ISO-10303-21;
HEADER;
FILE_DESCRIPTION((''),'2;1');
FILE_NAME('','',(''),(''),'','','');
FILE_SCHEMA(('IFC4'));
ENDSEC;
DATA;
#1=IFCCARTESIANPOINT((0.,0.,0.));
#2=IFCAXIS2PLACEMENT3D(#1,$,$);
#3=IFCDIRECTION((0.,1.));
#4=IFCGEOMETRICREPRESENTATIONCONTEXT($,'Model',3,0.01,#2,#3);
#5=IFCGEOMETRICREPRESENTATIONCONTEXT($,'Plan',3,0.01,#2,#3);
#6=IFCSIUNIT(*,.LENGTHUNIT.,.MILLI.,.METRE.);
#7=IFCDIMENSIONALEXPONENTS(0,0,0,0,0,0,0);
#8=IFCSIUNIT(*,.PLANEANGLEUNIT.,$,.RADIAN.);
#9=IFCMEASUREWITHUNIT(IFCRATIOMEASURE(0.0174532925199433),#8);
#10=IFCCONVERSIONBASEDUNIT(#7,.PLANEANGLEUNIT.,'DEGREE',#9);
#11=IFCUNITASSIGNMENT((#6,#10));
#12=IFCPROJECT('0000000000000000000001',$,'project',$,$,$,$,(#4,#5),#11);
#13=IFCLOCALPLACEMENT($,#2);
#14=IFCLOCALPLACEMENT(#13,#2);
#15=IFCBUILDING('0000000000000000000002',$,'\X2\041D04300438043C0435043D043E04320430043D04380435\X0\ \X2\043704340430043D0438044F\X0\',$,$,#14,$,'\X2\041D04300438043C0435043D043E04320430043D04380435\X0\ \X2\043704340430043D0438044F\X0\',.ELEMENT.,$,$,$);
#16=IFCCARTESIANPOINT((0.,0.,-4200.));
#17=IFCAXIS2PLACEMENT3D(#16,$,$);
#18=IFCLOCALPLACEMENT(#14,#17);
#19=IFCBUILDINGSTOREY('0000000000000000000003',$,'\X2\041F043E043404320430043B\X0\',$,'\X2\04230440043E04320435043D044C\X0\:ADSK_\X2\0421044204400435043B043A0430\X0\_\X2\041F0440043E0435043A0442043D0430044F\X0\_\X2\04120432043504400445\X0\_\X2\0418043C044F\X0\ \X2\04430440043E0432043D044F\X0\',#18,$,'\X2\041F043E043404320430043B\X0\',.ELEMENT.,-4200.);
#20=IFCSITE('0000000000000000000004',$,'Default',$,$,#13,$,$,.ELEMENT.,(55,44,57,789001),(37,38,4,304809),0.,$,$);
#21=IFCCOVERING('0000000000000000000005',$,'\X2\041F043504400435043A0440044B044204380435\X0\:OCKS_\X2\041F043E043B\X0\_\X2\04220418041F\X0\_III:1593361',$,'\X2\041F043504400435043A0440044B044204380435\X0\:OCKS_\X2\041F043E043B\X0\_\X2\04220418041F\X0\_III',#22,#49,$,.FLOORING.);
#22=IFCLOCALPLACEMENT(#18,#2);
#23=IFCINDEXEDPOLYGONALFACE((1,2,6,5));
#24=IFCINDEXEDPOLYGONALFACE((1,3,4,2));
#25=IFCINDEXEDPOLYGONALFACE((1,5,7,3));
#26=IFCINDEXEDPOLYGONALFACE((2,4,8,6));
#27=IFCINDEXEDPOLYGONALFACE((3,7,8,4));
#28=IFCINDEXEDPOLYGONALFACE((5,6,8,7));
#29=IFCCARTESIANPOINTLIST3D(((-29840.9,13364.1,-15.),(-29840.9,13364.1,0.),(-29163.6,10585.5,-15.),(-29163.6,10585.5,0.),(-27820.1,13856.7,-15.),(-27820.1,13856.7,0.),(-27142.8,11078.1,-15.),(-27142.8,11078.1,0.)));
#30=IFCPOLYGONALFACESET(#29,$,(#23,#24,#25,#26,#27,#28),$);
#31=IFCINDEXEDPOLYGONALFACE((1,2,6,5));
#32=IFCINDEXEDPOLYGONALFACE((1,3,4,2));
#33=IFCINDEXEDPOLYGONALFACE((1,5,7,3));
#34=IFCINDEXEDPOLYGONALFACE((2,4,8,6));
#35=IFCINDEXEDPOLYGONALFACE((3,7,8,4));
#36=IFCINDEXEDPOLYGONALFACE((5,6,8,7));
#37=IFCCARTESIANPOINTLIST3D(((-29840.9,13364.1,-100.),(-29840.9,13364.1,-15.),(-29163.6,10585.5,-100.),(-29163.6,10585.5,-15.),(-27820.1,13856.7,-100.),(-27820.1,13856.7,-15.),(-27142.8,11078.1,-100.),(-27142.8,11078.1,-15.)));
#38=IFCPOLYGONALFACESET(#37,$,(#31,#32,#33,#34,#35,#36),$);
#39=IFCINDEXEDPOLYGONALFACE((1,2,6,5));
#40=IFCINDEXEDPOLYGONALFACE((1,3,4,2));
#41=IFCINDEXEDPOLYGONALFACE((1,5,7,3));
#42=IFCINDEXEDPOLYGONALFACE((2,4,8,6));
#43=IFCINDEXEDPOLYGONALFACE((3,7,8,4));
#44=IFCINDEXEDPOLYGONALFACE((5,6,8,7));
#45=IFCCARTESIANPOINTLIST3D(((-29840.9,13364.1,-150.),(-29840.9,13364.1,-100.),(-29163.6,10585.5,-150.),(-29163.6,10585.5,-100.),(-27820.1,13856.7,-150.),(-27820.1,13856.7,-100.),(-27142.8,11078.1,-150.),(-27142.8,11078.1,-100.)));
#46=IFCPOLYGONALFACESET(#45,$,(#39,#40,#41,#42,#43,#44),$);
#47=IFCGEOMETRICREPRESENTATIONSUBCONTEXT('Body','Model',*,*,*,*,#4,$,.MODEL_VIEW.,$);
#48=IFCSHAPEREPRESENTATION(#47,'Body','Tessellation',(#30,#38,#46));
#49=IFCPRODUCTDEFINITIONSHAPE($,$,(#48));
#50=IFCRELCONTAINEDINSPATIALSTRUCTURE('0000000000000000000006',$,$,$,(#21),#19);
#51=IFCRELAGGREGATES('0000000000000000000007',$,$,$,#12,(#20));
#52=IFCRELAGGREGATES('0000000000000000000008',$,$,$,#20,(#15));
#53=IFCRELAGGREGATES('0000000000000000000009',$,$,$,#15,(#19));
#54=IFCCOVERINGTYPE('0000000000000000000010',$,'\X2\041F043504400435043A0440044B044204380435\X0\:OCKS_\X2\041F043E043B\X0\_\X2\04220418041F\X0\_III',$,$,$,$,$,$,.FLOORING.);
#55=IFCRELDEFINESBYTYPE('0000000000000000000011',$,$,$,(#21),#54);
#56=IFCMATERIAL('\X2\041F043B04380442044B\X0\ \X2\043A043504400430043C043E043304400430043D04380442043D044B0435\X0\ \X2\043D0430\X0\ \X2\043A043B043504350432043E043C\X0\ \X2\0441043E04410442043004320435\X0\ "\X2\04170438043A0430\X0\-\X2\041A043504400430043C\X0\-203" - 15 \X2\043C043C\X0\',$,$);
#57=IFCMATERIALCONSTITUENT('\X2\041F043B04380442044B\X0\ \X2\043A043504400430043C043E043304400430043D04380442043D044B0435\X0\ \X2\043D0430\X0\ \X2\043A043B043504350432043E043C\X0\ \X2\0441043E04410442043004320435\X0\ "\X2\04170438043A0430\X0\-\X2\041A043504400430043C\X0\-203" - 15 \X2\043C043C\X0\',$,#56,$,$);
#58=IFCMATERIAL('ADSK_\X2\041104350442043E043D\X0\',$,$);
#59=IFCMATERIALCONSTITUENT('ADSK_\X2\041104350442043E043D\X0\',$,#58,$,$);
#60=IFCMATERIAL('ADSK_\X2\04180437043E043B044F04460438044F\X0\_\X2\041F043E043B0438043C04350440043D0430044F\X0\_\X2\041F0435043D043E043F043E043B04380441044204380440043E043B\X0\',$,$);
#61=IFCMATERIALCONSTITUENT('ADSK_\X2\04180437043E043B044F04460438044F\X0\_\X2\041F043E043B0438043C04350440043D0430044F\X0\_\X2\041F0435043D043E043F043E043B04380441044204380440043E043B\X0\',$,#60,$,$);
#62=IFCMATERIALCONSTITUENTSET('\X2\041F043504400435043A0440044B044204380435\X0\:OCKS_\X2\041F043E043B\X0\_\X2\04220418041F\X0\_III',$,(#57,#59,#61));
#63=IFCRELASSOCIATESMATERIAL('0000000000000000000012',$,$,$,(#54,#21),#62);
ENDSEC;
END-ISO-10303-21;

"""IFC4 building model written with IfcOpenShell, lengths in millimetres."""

from ifc_helpers import new_model, entity, si_unit, converted_unit, direction, frame, origin, place, context, subcontext, project, spatial, indexed_curve, outline, extrude, material, constituent, constituent_set, type_object, element, save


model = new_model("IFC4")

# Units and contexts
model_context = context("Model", 3, precision=0.01, world=origin(), true_north=direction((0.0, 1.0)))
plan_context = context("Plan", 3, precision=0.01, world=origin(), true_north=direction((0.0, 1.0)))
body_context = subcontext(model_context, "Body", "Model", "MODEL_VIEW")
ifc_project = project(units=[si_unit("LENGTHUNIT", "METRE", prefix="MILLI"), converted_unit("PLANEANGLEUNIT", "DEGREE", entity("IfcRatioMeasure", 0.0174532925199433), si_unit("PLANEANGLEUNIT", "RADIAN"), dimensions=[0, 0, 0, 0, 0, 0, 0])], contexts=[model_context, plan_context])

# Site, building, storey
site_placement = place(None, frame((0.0, 0.0, 0.0)))
site = spatial("IfcSite", under=ifc_project, at=site_placement, Name="Default", CompositionType="ELEMENT", RefLatitude=(55, 44, 57, 789001), RefLongitude=(37, 38, 4, 304809), RefElevation=0.0)
building_placement = place(site_placement, origin())
building = spatial("IfcBuilding", under=site, at=building_placement, Name="Наименование здания", LongName="Наименование здания", CompositionType="ELEMENT")
storey_placement = place(building_placement, frame((0.0, 0.0, -4200.0)))
storey = spatial("IfcBuildingStorey", under=building, at=storey_placement, Name="Подвал", ObjectType="Уровень:ADSK_Стрелка_Проектная_Вверх_Имя уровня", LongName="Подвал", CompositionType="ELEMENT", Elevation=-4200.0)

# Covering
ifc_material_1 = material(Name="ADSK_Бетон")
ifc_material_2 = material(Name="ADSK_Изоляция_Полимерная_Пенополистирол")
ifc_material_3 = material(Name="Плиты керамогранитные на клеевом составе \"Зика-Керам-203\" - 15 мм")
ifc_constituent_1 = constituent(ifc_material_3, Name="Плиты керамогранитные на клеевом составе \"Зика-Керам-203\" - 15 мм")
ifc_constituent_2 = constituent(ifc_material_1, Name="ADSK_Бетон")
ifc_constituent_3 = constituent(ifc_material_2, Name="ADSK_Изоляция_Полимерная_Пенополистирол")
ifc_constituent_set_1 = constituent_set(constituents=[ifc_constituent_1, ifc_constituent_2, ifc_constituent_3], Name="Перекрытие:OCKS_Пол_ТИП_III")
covering_type_1 = type_object("IfcCoveringType", Name="Перекрытие:OCKS_Пол_ТИП_III", PredefinedType="FLOORING", material=ifc_constituent_set_1)
covering_1_placement = place(storey_placement, origin())
element("IfcCovering", 1, at=covering_1_placement, inside=storey, type_object=covering_type_1, material=ifc_constituent_set_1, Name="Перекрытие:OCKS_Пол_ТИП_III:1593361", ObjectType="Перекрытие:OCKS_Пол_ТИП_III", PredefinedType="FLOORING", context=body_context, shape_type="SweptSolid", body=[
    extrude(outline(indexed_curve([(-1040.0, -1430.0), (1040.0, -1430.0), (1040.0, 1430.0), (-1040.0, 1430.0), (-1040.0, -1430.0)], self_intersect=False)), frame((-28491.9, 12221.1, -15.0), z_axis=(0.0, 0.0, 1.0), x_axis=(0.971554, 0.236819, 0.0)), (0.0, 0.0, 1.0), 15.0),
    extrude(outline(indexed_curve([(-1040.0, -1430.0), (1040.0, -1430.0), (1040.0, 1430.0), (-1040.0, 1430.0), (-1040.0, -1430.0)], self_intersect=False)), frame((-28491.9, 12221.1, -100.0), z_axis=(0.0, 0.0, 1.0), x_axis=(0.971554, 0.236819, 0.0)), (0.0, 0.0, 1.0), 85.0),
    extrude(outline(indexed_curve([(-1040.0, -1430.0), (1040.0, -1430.0), (1040.0, 1430.0), (-1040.0, 1430.0), (-1040.0, -1430.0)], self_intersect=False)), frame((-28491.9, 12221.1, -150.0), z_axis=(0.0, 0.0, 1.0), x_axis=(0.971554, 0.236819, 0.0)), (0.0, 0.0, 1.0), 50.0),
])

save(model, "model.ifc")
